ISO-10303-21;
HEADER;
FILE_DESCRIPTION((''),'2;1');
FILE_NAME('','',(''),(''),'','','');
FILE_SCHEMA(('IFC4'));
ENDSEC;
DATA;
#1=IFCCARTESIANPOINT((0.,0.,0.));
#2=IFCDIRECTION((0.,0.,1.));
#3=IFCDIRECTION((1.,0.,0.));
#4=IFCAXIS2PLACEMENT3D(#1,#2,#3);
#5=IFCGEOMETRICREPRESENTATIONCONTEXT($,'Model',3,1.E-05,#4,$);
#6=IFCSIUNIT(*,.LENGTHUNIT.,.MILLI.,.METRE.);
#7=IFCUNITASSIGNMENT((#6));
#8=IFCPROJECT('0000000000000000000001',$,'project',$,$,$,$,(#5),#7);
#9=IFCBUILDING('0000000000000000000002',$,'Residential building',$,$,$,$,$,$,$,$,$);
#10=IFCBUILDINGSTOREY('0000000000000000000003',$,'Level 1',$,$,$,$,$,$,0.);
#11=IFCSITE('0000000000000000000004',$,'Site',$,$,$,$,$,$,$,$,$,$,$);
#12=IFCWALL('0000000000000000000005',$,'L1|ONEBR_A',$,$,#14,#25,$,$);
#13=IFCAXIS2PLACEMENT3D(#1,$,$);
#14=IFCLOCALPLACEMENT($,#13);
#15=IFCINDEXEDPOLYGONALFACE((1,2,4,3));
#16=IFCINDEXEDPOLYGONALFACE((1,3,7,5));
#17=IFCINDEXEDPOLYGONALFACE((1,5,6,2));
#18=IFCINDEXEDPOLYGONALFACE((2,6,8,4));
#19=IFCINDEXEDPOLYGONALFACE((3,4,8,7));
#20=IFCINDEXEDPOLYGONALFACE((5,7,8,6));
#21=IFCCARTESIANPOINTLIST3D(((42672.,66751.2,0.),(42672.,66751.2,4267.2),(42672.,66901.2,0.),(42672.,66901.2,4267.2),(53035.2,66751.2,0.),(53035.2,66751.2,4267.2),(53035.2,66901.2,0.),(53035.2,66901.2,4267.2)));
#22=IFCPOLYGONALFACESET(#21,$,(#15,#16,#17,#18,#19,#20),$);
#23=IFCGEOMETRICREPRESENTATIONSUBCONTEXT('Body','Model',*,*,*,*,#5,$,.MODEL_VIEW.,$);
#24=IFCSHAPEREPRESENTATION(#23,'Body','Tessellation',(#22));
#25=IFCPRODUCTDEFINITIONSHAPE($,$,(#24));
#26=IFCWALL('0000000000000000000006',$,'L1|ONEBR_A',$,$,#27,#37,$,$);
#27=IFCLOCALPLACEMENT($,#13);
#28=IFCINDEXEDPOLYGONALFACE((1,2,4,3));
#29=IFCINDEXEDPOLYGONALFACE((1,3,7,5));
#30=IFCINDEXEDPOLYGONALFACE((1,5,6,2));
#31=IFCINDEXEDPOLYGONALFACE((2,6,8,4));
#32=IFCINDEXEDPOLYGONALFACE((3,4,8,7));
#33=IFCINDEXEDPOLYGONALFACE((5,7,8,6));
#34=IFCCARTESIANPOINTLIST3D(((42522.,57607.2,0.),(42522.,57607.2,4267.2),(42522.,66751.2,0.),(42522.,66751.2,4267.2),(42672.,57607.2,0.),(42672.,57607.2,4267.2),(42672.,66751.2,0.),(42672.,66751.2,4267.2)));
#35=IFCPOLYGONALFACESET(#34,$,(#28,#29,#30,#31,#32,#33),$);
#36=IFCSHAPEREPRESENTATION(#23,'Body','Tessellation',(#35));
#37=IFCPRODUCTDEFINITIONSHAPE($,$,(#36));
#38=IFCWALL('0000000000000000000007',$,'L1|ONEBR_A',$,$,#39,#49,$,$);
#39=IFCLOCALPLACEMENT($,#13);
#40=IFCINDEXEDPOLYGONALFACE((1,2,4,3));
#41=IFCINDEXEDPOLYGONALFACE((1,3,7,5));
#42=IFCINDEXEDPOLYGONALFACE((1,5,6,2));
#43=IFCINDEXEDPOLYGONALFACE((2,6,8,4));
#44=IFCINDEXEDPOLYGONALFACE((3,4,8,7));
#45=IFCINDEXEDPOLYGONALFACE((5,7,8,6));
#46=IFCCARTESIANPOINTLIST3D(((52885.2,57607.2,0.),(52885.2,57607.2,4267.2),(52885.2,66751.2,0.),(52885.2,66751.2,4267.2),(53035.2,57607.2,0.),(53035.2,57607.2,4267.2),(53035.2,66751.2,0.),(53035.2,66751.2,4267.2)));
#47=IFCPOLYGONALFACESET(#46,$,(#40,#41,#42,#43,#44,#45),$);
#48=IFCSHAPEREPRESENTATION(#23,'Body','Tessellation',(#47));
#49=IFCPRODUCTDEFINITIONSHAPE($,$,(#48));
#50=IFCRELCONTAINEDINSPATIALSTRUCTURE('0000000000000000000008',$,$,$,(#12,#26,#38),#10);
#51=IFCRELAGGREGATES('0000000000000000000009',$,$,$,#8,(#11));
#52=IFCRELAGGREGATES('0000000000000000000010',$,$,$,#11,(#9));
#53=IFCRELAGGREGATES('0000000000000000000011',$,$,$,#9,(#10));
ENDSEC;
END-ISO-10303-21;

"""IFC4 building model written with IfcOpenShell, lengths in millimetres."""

from ifc_helpers import new_model, si_unit, frame, origin_with_axes, place, context, subcontext, project, spatial, indexed_curve, outline, extrude, element, save


model = new_model("IFC4")

# Units and contexts
model_context = context("Model", 3, precision=1e-05, world=origin_with_axes())
body_context = subcontext(model_context, "Body", "Model", "MODEL_VIEW")
ifc_project = project(units=[si_unit("LENGTHUNIT", "METRE", prefix="MILLI")], contexts=[model_context])

# Site, building, storey
site = spatial("IfcSite", under=ifc_project, Name="Site")
building = spatial("IfcBuilding", under=site, Name="Residential building")
storey = spatial("IfcBuildingStorey", under=building, Name="Level 1", Elevation=0.0)

# Walls
for number, where, z_axis, x_axis, name in (
    (1, (42672.0, 66751.2, 0.0), (0.0, 0.0, 1.0), (1.0, 0.0, 0.0), "L1|ONEBR_A"),
):
    element("IfcWall", number, at=place(None, frame(where, z_axis=z_axis, x_axis=x_axis)), inside=storey, Name=name, context=body_context, shape_type="SweptSolid", body=[
        extrude(outline(indexed_curve([(0.0, 0.0), (0.0, 150.0), (10363.2, 150.0), (10363.2, 0.0), (0.0, 0.0)], self_intersect=False)), origin_with_axes(), (0.0, 0.0, 1.0), 4267.2),
    ])
for number, where, z_axis, x_axis, name in (
    (2, (42672.0, 57607.2, 0.0), (0.0, 0.0, 1.0), (0.0, 1.0, 0.0), "L1|ONEBR_A"),
    (3, (53035.2, 57607.2, 0.0), (0.0, 0.0, 1.0), (0.0, 1.0, 0.0), "L1|ONEBR_A"),
):
    element("IfcWall", number, at=place(None, frame(where, z_axis=z_axis, x_axis=x_axis)), inside=storey, Name=name, context=body_context, shape_type="SweptSolid", body=[
        extrude(outline(indexed_curve([(0.0, 0.0), (0.0, 150.0), (9144.0, 150.0), (9144.0, 0.0), (0.0, 0.0)], self_intersect=False)), origin_with_axes(), (0.0, 0.0, 1.0), 4267.2),
    ])

save(model, "model.ifc")
